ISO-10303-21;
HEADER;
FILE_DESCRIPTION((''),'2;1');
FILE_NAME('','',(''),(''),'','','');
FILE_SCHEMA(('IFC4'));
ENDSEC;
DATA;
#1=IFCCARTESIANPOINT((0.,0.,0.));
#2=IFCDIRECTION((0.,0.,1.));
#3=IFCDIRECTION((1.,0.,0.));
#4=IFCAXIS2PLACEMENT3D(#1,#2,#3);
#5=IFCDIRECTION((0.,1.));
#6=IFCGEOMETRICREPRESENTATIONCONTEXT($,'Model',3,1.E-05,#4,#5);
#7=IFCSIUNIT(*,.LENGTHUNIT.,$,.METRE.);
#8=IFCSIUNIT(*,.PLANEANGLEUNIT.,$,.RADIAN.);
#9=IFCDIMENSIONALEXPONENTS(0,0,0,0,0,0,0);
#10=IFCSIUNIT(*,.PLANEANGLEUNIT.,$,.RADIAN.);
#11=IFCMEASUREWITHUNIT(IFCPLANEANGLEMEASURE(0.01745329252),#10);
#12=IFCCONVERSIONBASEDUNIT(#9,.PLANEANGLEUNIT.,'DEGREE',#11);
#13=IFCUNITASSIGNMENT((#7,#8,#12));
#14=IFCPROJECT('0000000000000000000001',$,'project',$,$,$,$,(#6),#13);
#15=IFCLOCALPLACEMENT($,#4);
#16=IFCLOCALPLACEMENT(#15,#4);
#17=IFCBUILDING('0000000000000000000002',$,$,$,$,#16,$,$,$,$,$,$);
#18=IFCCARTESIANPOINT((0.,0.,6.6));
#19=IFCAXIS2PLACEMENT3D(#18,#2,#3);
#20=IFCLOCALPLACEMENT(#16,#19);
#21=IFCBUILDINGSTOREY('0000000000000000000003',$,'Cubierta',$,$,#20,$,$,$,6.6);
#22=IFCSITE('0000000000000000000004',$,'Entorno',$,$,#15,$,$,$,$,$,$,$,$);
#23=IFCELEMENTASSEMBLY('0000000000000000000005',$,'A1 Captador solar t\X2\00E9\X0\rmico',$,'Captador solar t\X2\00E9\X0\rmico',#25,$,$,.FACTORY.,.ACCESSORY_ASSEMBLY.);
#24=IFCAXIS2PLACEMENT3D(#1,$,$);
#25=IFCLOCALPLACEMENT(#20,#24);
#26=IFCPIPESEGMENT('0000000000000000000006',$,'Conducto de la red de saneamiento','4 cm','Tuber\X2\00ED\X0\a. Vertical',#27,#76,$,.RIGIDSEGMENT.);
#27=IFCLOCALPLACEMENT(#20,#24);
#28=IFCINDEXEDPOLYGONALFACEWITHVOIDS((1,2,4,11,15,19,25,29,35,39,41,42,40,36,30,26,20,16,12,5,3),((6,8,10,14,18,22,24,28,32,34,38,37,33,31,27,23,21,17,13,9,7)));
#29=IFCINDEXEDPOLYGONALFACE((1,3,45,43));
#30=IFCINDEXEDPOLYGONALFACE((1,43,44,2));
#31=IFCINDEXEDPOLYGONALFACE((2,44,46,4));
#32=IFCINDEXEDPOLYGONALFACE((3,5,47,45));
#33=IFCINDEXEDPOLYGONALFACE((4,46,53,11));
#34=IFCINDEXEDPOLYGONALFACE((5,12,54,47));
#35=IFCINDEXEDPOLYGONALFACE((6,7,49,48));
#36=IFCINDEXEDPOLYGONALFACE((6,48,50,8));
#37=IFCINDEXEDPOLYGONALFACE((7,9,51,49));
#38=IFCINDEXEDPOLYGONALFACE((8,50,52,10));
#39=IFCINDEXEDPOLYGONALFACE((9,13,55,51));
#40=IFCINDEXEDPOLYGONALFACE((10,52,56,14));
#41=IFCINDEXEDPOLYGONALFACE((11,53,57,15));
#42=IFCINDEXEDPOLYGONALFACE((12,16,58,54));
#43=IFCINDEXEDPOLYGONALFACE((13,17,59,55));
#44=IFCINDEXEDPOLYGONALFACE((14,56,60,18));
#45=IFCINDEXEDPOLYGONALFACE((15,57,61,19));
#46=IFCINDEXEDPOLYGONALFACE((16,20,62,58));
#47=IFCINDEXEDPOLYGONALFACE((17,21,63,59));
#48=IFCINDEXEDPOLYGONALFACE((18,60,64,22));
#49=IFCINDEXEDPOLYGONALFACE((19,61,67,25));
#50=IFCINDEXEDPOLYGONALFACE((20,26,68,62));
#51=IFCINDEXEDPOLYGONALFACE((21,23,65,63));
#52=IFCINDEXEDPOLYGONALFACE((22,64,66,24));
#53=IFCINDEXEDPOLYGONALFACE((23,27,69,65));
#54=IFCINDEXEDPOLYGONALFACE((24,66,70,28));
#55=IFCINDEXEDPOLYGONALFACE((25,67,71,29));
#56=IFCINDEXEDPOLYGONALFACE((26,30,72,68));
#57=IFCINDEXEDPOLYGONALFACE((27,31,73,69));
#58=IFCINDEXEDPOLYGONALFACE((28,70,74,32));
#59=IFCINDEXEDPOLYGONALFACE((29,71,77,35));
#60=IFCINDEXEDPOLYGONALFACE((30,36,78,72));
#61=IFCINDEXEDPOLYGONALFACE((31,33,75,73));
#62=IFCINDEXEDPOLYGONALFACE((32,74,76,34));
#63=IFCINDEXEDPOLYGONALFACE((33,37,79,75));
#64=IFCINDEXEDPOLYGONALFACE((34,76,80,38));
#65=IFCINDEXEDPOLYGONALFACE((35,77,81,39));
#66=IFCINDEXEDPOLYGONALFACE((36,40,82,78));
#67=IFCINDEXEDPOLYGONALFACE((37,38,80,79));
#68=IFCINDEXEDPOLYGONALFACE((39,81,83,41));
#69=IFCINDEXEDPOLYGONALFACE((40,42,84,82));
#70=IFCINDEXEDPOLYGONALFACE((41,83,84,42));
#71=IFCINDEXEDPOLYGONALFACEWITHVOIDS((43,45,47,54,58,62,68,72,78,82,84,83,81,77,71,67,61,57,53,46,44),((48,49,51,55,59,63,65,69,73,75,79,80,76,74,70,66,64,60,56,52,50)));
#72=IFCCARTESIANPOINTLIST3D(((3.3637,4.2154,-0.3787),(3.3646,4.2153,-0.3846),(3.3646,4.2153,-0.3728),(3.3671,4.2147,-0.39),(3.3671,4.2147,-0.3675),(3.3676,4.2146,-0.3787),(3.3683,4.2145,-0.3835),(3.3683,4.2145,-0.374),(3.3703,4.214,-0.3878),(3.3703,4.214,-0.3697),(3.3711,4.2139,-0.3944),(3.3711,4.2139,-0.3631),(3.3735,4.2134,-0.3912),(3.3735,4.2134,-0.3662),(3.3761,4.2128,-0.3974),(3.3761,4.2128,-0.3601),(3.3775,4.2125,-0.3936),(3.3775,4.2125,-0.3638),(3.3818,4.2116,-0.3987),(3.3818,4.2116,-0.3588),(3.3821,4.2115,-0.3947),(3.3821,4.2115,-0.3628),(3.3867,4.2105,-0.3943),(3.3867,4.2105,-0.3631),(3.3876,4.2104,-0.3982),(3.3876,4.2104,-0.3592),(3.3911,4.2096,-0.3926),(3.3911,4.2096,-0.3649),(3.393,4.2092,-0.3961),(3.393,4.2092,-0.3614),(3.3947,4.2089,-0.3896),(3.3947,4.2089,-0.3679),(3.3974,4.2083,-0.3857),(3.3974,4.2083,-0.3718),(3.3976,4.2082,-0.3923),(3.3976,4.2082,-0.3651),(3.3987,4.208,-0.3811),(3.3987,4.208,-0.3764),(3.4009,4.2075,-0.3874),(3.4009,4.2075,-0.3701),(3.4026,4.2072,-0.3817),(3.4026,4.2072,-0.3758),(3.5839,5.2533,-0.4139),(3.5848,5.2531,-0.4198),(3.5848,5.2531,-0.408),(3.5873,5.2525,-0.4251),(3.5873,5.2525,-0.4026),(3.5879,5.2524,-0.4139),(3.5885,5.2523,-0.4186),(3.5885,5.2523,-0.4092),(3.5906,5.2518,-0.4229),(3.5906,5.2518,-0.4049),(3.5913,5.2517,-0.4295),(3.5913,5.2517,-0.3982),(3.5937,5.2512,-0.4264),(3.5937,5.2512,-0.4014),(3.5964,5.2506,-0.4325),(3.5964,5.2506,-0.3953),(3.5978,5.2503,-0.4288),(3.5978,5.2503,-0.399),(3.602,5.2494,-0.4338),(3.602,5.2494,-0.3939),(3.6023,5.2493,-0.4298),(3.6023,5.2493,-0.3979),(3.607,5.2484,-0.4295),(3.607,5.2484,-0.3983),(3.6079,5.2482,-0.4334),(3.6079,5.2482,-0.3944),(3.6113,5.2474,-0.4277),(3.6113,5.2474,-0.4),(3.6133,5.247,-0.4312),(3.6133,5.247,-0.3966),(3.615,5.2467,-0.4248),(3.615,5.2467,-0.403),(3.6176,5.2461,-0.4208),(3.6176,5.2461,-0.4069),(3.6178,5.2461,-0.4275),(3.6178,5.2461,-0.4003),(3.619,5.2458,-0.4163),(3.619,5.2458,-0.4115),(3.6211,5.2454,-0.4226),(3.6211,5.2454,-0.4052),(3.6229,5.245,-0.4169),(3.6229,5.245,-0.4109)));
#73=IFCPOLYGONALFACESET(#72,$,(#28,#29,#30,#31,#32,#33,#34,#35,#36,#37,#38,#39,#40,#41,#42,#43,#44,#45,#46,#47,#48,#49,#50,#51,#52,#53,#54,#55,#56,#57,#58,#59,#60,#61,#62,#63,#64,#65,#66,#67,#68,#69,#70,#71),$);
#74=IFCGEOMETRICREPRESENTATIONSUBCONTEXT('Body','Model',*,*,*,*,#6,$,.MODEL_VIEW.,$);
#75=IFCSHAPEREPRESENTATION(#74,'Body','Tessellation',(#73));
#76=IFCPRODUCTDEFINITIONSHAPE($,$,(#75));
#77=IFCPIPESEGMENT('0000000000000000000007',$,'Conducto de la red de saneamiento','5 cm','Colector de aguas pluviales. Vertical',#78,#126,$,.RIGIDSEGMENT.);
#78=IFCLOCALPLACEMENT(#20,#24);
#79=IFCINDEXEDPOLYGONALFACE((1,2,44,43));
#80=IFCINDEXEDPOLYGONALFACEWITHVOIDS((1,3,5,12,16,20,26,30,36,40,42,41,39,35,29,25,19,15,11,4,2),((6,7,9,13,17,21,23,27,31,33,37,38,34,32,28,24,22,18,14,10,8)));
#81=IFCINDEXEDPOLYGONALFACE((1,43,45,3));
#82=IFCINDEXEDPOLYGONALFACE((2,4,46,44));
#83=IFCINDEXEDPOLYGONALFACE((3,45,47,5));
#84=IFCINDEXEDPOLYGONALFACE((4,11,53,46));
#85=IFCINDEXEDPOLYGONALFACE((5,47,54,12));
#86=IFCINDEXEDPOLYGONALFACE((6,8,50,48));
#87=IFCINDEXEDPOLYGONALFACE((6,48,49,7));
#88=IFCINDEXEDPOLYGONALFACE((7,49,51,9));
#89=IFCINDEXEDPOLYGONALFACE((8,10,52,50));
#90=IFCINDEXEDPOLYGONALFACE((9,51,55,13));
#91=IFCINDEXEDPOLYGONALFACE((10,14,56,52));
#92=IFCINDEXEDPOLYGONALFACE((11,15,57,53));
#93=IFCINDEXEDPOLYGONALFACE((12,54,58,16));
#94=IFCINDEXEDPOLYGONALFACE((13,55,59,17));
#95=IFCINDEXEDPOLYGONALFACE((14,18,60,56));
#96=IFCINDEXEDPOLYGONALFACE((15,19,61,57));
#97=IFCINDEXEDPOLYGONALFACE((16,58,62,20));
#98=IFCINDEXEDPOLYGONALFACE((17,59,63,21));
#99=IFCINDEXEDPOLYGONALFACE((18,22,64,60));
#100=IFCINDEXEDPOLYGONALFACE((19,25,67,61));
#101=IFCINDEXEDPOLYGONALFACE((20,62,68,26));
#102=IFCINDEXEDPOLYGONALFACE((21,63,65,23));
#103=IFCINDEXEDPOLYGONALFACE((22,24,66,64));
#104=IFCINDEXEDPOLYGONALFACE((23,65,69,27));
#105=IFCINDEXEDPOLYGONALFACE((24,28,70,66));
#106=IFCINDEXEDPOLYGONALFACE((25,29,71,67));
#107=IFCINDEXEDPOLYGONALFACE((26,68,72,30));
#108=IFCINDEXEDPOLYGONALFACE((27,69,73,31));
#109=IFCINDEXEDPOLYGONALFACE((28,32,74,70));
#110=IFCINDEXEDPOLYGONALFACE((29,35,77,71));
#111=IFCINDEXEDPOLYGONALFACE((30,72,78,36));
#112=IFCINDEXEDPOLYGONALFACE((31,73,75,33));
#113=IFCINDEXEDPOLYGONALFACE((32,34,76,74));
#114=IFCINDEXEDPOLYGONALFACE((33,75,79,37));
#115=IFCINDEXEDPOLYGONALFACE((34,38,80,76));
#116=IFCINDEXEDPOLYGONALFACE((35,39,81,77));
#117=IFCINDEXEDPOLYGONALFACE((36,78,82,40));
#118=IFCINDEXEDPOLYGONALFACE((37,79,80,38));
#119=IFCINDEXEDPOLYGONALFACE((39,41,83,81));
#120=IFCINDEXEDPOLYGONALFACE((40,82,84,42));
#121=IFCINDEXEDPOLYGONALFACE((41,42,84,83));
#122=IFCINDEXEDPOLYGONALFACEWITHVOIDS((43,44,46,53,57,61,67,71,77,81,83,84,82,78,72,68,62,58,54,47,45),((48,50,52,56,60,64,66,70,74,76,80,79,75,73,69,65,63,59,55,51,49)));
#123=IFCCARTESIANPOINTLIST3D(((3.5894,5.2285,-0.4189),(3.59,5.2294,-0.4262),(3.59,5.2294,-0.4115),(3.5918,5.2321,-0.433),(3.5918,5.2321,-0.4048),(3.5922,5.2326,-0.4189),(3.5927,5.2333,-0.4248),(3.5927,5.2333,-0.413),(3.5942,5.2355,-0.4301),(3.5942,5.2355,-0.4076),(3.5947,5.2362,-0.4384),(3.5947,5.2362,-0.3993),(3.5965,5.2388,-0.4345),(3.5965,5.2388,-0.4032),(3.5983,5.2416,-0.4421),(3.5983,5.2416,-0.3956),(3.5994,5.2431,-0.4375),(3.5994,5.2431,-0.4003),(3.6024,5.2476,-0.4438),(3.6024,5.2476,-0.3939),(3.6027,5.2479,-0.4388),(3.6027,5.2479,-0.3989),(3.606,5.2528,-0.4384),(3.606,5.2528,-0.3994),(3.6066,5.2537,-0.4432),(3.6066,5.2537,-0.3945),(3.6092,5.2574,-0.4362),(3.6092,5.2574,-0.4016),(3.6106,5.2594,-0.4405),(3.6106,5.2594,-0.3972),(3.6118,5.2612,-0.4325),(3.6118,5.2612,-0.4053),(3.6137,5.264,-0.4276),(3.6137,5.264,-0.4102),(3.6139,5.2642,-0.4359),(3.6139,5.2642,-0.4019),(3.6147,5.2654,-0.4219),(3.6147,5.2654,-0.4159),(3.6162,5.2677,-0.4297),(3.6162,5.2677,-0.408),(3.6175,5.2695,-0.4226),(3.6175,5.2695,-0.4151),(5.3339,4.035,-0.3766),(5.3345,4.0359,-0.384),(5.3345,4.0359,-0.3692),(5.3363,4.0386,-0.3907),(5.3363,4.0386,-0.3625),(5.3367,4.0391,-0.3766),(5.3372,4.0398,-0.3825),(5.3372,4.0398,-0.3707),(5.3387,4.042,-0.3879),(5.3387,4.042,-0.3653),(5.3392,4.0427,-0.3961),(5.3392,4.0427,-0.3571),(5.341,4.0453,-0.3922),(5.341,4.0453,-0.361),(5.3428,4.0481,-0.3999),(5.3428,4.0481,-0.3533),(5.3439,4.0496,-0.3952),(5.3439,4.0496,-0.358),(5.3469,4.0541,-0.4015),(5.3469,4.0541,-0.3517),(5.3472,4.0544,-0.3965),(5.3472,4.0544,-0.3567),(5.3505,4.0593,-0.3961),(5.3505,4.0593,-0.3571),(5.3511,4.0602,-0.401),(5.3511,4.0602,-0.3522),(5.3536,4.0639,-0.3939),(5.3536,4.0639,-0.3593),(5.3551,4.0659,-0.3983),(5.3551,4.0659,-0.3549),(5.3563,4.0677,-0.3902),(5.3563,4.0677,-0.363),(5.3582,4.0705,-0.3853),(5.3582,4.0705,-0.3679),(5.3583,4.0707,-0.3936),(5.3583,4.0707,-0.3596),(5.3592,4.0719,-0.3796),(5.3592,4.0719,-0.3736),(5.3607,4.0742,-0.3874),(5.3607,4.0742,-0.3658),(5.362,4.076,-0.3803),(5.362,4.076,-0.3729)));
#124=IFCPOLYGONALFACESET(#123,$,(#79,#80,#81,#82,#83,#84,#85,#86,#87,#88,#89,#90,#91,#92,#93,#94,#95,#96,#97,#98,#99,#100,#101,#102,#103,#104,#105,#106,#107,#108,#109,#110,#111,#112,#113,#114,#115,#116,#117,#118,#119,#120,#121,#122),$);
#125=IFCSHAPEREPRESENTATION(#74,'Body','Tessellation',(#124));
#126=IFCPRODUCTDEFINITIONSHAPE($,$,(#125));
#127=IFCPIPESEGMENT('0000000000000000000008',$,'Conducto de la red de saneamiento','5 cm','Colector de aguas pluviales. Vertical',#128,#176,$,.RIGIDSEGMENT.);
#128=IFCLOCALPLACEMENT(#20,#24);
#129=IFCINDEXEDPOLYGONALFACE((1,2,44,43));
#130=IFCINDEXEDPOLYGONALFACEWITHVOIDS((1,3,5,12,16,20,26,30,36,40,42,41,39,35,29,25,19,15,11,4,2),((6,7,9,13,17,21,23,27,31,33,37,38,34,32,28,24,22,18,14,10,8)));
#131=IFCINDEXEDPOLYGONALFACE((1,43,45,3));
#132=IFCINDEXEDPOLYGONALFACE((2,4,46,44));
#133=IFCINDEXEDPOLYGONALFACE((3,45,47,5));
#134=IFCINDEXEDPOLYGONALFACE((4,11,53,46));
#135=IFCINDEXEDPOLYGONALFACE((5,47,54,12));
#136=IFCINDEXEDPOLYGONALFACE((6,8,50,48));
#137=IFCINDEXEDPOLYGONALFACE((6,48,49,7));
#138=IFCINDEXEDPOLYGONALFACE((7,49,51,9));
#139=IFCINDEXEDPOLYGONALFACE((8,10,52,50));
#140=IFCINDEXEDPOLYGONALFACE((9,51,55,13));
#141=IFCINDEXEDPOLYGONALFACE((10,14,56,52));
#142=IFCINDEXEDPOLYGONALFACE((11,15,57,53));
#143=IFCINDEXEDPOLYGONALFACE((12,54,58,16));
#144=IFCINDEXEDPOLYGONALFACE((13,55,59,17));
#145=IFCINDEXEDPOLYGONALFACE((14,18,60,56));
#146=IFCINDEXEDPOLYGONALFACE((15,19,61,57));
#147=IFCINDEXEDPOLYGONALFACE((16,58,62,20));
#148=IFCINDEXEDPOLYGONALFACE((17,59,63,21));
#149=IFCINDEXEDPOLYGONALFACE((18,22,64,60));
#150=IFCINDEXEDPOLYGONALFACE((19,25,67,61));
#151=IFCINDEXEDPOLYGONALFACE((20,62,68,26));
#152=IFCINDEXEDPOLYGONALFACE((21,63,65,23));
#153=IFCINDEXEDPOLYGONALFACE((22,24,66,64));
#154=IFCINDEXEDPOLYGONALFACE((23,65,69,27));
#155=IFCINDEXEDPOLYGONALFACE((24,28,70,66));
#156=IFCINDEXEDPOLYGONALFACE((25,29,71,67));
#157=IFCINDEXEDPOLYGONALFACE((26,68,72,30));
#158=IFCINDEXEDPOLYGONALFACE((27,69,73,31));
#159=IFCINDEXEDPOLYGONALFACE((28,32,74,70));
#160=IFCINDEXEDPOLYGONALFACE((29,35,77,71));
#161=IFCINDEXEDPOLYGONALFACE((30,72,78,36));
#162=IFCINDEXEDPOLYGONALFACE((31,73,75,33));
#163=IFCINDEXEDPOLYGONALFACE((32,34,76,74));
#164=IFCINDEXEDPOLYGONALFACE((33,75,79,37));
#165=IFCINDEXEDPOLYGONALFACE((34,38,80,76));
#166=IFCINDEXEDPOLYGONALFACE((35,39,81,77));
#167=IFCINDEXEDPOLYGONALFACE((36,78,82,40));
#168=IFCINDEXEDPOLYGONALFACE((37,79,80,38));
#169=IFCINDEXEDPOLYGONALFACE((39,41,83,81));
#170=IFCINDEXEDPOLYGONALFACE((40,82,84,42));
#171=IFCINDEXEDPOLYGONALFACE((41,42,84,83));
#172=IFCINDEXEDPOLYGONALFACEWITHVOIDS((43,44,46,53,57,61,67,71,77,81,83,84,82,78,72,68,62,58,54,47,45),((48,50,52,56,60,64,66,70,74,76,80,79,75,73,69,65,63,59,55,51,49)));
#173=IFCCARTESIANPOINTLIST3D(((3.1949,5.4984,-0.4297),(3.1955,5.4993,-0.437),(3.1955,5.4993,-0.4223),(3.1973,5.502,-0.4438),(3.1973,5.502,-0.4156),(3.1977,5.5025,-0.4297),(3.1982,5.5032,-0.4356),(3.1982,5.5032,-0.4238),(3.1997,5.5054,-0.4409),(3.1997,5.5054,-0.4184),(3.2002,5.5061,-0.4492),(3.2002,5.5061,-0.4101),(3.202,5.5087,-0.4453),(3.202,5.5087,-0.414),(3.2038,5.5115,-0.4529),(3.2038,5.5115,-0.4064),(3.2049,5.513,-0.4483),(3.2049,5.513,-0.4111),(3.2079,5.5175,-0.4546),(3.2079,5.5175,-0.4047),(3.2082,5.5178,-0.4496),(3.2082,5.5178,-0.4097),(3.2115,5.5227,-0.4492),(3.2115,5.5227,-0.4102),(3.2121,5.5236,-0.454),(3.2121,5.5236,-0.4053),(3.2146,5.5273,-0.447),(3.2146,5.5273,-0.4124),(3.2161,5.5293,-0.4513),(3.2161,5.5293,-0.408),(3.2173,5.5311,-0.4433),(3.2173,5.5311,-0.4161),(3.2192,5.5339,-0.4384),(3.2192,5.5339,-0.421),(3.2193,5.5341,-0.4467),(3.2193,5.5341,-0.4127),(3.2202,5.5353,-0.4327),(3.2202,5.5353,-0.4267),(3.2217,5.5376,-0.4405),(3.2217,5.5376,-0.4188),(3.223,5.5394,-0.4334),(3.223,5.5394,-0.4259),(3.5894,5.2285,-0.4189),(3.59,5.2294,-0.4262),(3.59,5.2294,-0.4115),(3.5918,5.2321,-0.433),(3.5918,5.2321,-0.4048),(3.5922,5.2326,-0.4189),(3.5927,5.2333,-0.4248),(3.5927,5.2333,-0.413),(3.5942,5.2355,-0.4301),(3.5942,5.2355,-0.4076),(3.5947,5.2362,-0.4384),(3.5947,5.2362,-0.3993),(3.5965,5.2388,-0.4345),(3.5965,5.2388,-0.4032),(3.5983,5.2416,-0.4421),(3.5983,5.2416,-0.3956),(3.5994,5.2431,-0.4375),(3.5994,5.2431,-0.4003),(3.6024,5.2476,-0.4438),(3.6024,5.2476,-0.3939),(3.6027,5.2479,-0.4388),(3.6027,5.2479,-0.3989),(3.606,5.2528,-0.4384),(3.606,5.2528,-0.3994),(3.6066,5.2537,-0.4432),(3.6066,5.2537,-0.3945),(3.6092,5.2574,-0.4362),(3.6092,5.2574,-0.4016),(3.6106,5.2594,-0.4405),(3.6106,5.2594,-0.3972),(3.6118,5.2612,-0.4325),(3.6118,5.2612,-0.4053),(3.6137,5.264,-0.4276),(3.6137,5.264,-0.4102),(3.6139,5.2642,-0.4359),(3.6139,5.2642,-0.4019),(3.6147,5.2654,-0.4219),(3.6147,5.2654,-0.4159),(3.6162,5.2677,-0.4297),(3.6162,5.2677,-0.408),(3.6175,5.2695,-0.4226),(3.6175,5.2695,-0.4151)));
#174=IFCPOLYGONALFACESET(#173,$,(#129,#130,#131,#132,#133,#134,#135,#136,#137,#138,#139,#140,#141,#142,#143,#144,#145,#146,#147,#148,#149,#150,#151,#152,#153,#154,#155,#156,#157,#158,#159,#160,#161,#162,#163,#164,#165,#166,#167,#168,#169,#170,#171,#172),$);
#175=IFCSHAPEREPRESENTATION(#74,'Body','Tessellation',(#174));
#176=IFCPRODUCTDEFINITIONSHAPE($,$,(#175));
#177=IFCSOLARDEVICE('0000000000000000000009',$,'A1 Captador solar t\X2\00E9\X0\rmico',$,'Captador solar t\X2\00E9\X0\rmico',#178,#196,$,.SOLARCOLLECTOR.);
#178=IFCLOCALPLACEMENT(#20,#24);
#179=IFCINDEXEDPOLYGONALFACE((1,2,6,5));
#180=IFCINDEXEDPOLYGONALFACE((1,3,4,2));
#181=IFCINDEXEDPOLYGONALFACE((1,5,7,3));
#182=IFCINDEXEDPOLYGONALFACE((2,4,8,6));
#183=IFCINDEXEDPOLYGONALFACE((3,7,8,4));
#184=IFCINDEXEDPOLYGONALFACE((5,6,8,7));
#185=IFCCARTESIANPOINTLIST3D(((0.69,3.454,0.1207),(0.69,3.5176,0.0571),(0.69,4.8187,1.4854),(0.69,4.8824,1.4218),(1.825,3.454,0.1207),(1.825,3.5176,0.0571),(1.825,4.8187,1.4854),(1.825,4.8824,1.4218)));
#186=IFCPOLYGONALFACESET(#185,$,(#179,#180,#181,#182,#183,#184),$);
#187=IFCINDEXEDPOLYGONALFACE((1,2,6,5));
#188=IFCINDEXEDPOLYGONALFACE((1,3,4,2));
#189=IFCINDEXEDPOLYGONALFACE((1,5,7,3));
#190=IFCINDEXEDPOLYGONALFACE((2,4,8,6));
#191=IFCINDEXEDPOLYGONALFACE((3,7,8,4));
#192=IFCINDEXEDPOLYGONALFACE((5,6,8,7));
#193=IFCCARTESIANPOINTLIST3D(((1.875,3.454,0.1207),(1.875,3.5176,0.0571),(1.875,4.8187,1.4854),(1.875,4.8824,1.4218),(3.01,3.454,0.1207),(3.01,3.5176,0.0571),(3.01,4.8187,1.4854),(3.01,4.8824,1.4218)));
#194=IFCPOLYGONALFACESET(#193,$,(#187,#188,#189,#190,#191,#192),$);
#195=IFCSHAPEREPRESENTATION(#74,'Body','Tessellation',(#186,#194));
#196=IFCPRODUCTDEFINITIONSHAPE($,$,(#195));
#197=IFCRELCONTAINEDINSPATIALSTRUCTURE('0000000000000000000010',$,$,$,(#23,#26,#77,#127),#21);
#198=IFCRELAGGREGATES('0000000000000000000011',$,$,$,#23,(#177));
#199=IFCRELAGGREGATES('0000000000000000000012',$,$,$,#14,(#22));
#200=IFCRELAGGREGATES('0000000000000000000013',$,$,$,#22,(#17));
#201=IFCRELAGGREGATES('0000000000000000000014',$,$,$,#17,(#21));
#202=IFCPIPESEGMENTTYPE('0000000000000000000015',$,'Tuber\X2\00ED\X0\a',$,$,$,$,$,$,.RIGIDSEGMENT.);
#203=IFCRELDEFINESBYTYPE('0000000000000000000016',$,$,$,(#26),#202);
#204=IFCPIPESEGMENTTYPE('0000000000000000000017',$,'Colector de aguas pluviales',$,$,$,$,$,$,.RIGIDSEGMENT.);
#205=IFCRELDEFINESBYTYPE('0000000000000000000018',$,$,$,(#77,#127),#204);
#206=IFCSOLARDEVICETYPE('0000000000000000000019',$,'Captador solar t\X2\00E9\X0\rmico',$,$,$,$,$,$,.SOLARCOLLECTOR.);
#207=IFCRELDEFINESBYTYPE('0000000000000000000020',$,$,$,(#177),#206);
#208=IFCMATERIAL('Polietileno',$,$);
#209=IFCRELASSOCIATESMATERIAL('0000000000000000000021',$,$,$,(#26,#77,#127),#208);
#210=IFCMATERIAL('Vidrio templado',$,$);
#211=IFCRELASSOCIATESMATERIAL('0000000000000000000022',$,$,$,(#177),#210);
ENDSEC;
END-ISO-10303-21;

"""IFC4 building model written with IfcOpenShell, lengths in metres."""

from ifc_helpers import new_model, entity, si_unit, converted_unit, direction, frame, origin_with_axes, origin_2d_with_axis, place, context, subcontext, project, spatial, rectangle, hollow_circle, extrude, material, type_object, element, aggregate, save


model = new_model("IFC4")

# Units and contexts
model_context = context("Model", 3, precision=1e-05, world=origin_with_axes(), true_north=direction((0.0, 1.0)))
body_context = subcontext(model_context, "Body", "Model", "MODEL_VIEW")
ifc_project = project(units=[si_unit("LENGTHUNIT", "METRE"), si_unit("PLANEANGLEUNIT", "RADIAN"), converted_unit("PLANEANGLEUNIT", "DEGREE", entity("IfcPlaneAngleMeasure", 0.01745329252), si_unit("PLANEANGLEUNIT", "RADIAN"), dimensions=[0, 0, 0, 0, 0, 0, 0])], contexts=[model_context])

# Site, building, storey
site_placement = place(None, origin_with_axes())
site = spatial("IfcSite", under=ifc_project, at=site_placement, Name="Entorno")
building_placement = place(site_placement, origin_with_axes())
building = spatial("IfcBuilding", under=site, at=building_placement)
storey_placement = place(building_placement, frame((0.0, 0.0, 6.6), z_axis=(0.0, 0.0, 1.0), x_axis=(1.0, 0.0, 0.0)))
storey = spatial("IfcBuildingStorey", under=building, at=storey_placement, Name="Cubierta", Elevation=6.6)

# Element assembly
assembly_1_placement = place(storey_placement, frame((1.85, 4.2, 0.0), z_axis=(0.0, 0.0, 1.0), x_axis=(1.0, 0.0, 0.0)))
assembly_1 = element("IfcElementAssembly", 1, at=assembly_1_placement, inside=storey, Name="A1 Captador solar térmico", ObjectType="Captador solar térmico", AssemblyPlace="FACTORY", PredefinedType="ACCESSORY_ASSEMBLY")

# Pipe segments
ifc_material_1 = material(Name="Polietileno")
pipe_segment_type_1 = type_object("IfcPipeSegmentType", Name="Tubería", PredefinedType="RIGIDSEGMENT")
pipe_segment_1_placement = place(storey_placement, frame((3.3832, 4.2113, -0.3787), z_axis=(0.207605, 0.978213, 0.0), x_axis=(-0.978213, 0.207605, 0.0)))
element("IfcPipeSegment", 2, at=pipe_segment_1_placement, inside=storey, type_object=pipe_segment_type_1, material=ifc_material_1, Name="Conducto de la red de saneamiento", Description="4 cm", ObjectType="Tubería. Vertical", PredefinedType="RIGIDSEGMENT", context=body_context, shape_type="SweptSolid", body=[
    extrude(hollow_circle(Radius=0.02, WallThickness=0.004, at=origin_2d_with_axis()), origin_with_axes(), (0.0, -0.0331, 0.999452), 1.0615),
])
pipe_segment_type_2 = type_object("IfcPipeSegmentType", Name="Colector de aguas pluviales", PredefinedType="RIGIDSEGMENT")
pipe_segment_2_placement = place(storey_placement, frame((5.348, 4.0556, -0.3766), z_axis=(-0.825332, 0.564647, 0.0), x_axis=(-0.564647, -0.825332, 0.0)))
element("IfcPipeSegment", 3, at=pipe_segment_2_placement, inside=storey, type_object=pipe_segment_type_2, material=ifc_material_1, Name="Conducto de la red de saneamiento", Description="5 cm", ObjectType="Colector de aguas pluviales. Vertical", PredefinedType="RIGIDSEGMENT", context=body_context, shape_type="SweptSolid", body=[
    extrude(hollow_circle(Radius=0.025, WallThickness=0.005, at=origin_2d_with_axis()), origin_with_axes(), (0.0, -0.019996, 0.9998), 2.1141),
])
pipe_segment_3_placement = place(storey_placement, frame((3.6035, 5.2491, -0.4189), z_axis=(-0.825332, 0.564647, 0.0), x_axis=(-0.564647, -0.825332, 0.0)))
element("IfcPipeSegment", 4, at=pipe_segment_3_placement, inside=storey, type_object=pipe_segment_type_2, material=ifc_material_1, Name="Conducto de la red de saneamiento", Description="5 cm", ObjectType="Colector de aguas pluviales. Vertical", PredefinedType="RIGIDSEGMENT", context=body_context, shape_type="SweptSolid", body=[
    extrude(hollow_circle(Radius=0.025, WallThickness=0.005, at=origin_2d_with_axis()), origin_with_axes(), (0.0, -0.022594, 0.999745), 0.4781),
])

# Solar device
ifc_material_2 = material(Name="Vidrio templado")
solar_device_type = type_object("IfcSolarDeviceType", Name="Captador solar térmico", PredefinedType="SOLARCOLLECTOR")
solar_device_placement = place(assembly_1_placement, frame((0.0, 0.0, 0.7394), z_axis=(0.0, -0.707107, 0.707107), x_axis=(1.0, 0.0, 0.0)))
solar_device = element("IfcSolarDevice", 5, at=solar_device_placement, type_object=solar_device_type, material=ifc_material_2, Name="A1 Captador solar térmico", ObjectType="Captador solar térmico", PredefinedType="SOLARCOLLECTOR", context=body_context, shape_type="SweptSolid", body=[
    extrude(rectangle(XDim=1.135, YDim=1.93, at=origin_2d_with_axis()), frame((-0.5925, 0.0, 0.0), z_axis=(0.0, 0.0, 1.0), x_axis=(1.0, 0.0, 0.0)), (0.0, 0.0, 1.0), 0.09),
    extrude(rectangle(XDim=1.135, YDim=1.93, at=origin_2d_with_axis()), frame((0.5925, 0.0, 0.0), z_axis=(0.0, 0.0, 1.0), x_axis=(1.0, 0.0, 0.0)), (0.0, 0.0, 1.0), 0.09),
])
aggregate(assembly_1, [solar_device])

save(model, "model.ifc")
